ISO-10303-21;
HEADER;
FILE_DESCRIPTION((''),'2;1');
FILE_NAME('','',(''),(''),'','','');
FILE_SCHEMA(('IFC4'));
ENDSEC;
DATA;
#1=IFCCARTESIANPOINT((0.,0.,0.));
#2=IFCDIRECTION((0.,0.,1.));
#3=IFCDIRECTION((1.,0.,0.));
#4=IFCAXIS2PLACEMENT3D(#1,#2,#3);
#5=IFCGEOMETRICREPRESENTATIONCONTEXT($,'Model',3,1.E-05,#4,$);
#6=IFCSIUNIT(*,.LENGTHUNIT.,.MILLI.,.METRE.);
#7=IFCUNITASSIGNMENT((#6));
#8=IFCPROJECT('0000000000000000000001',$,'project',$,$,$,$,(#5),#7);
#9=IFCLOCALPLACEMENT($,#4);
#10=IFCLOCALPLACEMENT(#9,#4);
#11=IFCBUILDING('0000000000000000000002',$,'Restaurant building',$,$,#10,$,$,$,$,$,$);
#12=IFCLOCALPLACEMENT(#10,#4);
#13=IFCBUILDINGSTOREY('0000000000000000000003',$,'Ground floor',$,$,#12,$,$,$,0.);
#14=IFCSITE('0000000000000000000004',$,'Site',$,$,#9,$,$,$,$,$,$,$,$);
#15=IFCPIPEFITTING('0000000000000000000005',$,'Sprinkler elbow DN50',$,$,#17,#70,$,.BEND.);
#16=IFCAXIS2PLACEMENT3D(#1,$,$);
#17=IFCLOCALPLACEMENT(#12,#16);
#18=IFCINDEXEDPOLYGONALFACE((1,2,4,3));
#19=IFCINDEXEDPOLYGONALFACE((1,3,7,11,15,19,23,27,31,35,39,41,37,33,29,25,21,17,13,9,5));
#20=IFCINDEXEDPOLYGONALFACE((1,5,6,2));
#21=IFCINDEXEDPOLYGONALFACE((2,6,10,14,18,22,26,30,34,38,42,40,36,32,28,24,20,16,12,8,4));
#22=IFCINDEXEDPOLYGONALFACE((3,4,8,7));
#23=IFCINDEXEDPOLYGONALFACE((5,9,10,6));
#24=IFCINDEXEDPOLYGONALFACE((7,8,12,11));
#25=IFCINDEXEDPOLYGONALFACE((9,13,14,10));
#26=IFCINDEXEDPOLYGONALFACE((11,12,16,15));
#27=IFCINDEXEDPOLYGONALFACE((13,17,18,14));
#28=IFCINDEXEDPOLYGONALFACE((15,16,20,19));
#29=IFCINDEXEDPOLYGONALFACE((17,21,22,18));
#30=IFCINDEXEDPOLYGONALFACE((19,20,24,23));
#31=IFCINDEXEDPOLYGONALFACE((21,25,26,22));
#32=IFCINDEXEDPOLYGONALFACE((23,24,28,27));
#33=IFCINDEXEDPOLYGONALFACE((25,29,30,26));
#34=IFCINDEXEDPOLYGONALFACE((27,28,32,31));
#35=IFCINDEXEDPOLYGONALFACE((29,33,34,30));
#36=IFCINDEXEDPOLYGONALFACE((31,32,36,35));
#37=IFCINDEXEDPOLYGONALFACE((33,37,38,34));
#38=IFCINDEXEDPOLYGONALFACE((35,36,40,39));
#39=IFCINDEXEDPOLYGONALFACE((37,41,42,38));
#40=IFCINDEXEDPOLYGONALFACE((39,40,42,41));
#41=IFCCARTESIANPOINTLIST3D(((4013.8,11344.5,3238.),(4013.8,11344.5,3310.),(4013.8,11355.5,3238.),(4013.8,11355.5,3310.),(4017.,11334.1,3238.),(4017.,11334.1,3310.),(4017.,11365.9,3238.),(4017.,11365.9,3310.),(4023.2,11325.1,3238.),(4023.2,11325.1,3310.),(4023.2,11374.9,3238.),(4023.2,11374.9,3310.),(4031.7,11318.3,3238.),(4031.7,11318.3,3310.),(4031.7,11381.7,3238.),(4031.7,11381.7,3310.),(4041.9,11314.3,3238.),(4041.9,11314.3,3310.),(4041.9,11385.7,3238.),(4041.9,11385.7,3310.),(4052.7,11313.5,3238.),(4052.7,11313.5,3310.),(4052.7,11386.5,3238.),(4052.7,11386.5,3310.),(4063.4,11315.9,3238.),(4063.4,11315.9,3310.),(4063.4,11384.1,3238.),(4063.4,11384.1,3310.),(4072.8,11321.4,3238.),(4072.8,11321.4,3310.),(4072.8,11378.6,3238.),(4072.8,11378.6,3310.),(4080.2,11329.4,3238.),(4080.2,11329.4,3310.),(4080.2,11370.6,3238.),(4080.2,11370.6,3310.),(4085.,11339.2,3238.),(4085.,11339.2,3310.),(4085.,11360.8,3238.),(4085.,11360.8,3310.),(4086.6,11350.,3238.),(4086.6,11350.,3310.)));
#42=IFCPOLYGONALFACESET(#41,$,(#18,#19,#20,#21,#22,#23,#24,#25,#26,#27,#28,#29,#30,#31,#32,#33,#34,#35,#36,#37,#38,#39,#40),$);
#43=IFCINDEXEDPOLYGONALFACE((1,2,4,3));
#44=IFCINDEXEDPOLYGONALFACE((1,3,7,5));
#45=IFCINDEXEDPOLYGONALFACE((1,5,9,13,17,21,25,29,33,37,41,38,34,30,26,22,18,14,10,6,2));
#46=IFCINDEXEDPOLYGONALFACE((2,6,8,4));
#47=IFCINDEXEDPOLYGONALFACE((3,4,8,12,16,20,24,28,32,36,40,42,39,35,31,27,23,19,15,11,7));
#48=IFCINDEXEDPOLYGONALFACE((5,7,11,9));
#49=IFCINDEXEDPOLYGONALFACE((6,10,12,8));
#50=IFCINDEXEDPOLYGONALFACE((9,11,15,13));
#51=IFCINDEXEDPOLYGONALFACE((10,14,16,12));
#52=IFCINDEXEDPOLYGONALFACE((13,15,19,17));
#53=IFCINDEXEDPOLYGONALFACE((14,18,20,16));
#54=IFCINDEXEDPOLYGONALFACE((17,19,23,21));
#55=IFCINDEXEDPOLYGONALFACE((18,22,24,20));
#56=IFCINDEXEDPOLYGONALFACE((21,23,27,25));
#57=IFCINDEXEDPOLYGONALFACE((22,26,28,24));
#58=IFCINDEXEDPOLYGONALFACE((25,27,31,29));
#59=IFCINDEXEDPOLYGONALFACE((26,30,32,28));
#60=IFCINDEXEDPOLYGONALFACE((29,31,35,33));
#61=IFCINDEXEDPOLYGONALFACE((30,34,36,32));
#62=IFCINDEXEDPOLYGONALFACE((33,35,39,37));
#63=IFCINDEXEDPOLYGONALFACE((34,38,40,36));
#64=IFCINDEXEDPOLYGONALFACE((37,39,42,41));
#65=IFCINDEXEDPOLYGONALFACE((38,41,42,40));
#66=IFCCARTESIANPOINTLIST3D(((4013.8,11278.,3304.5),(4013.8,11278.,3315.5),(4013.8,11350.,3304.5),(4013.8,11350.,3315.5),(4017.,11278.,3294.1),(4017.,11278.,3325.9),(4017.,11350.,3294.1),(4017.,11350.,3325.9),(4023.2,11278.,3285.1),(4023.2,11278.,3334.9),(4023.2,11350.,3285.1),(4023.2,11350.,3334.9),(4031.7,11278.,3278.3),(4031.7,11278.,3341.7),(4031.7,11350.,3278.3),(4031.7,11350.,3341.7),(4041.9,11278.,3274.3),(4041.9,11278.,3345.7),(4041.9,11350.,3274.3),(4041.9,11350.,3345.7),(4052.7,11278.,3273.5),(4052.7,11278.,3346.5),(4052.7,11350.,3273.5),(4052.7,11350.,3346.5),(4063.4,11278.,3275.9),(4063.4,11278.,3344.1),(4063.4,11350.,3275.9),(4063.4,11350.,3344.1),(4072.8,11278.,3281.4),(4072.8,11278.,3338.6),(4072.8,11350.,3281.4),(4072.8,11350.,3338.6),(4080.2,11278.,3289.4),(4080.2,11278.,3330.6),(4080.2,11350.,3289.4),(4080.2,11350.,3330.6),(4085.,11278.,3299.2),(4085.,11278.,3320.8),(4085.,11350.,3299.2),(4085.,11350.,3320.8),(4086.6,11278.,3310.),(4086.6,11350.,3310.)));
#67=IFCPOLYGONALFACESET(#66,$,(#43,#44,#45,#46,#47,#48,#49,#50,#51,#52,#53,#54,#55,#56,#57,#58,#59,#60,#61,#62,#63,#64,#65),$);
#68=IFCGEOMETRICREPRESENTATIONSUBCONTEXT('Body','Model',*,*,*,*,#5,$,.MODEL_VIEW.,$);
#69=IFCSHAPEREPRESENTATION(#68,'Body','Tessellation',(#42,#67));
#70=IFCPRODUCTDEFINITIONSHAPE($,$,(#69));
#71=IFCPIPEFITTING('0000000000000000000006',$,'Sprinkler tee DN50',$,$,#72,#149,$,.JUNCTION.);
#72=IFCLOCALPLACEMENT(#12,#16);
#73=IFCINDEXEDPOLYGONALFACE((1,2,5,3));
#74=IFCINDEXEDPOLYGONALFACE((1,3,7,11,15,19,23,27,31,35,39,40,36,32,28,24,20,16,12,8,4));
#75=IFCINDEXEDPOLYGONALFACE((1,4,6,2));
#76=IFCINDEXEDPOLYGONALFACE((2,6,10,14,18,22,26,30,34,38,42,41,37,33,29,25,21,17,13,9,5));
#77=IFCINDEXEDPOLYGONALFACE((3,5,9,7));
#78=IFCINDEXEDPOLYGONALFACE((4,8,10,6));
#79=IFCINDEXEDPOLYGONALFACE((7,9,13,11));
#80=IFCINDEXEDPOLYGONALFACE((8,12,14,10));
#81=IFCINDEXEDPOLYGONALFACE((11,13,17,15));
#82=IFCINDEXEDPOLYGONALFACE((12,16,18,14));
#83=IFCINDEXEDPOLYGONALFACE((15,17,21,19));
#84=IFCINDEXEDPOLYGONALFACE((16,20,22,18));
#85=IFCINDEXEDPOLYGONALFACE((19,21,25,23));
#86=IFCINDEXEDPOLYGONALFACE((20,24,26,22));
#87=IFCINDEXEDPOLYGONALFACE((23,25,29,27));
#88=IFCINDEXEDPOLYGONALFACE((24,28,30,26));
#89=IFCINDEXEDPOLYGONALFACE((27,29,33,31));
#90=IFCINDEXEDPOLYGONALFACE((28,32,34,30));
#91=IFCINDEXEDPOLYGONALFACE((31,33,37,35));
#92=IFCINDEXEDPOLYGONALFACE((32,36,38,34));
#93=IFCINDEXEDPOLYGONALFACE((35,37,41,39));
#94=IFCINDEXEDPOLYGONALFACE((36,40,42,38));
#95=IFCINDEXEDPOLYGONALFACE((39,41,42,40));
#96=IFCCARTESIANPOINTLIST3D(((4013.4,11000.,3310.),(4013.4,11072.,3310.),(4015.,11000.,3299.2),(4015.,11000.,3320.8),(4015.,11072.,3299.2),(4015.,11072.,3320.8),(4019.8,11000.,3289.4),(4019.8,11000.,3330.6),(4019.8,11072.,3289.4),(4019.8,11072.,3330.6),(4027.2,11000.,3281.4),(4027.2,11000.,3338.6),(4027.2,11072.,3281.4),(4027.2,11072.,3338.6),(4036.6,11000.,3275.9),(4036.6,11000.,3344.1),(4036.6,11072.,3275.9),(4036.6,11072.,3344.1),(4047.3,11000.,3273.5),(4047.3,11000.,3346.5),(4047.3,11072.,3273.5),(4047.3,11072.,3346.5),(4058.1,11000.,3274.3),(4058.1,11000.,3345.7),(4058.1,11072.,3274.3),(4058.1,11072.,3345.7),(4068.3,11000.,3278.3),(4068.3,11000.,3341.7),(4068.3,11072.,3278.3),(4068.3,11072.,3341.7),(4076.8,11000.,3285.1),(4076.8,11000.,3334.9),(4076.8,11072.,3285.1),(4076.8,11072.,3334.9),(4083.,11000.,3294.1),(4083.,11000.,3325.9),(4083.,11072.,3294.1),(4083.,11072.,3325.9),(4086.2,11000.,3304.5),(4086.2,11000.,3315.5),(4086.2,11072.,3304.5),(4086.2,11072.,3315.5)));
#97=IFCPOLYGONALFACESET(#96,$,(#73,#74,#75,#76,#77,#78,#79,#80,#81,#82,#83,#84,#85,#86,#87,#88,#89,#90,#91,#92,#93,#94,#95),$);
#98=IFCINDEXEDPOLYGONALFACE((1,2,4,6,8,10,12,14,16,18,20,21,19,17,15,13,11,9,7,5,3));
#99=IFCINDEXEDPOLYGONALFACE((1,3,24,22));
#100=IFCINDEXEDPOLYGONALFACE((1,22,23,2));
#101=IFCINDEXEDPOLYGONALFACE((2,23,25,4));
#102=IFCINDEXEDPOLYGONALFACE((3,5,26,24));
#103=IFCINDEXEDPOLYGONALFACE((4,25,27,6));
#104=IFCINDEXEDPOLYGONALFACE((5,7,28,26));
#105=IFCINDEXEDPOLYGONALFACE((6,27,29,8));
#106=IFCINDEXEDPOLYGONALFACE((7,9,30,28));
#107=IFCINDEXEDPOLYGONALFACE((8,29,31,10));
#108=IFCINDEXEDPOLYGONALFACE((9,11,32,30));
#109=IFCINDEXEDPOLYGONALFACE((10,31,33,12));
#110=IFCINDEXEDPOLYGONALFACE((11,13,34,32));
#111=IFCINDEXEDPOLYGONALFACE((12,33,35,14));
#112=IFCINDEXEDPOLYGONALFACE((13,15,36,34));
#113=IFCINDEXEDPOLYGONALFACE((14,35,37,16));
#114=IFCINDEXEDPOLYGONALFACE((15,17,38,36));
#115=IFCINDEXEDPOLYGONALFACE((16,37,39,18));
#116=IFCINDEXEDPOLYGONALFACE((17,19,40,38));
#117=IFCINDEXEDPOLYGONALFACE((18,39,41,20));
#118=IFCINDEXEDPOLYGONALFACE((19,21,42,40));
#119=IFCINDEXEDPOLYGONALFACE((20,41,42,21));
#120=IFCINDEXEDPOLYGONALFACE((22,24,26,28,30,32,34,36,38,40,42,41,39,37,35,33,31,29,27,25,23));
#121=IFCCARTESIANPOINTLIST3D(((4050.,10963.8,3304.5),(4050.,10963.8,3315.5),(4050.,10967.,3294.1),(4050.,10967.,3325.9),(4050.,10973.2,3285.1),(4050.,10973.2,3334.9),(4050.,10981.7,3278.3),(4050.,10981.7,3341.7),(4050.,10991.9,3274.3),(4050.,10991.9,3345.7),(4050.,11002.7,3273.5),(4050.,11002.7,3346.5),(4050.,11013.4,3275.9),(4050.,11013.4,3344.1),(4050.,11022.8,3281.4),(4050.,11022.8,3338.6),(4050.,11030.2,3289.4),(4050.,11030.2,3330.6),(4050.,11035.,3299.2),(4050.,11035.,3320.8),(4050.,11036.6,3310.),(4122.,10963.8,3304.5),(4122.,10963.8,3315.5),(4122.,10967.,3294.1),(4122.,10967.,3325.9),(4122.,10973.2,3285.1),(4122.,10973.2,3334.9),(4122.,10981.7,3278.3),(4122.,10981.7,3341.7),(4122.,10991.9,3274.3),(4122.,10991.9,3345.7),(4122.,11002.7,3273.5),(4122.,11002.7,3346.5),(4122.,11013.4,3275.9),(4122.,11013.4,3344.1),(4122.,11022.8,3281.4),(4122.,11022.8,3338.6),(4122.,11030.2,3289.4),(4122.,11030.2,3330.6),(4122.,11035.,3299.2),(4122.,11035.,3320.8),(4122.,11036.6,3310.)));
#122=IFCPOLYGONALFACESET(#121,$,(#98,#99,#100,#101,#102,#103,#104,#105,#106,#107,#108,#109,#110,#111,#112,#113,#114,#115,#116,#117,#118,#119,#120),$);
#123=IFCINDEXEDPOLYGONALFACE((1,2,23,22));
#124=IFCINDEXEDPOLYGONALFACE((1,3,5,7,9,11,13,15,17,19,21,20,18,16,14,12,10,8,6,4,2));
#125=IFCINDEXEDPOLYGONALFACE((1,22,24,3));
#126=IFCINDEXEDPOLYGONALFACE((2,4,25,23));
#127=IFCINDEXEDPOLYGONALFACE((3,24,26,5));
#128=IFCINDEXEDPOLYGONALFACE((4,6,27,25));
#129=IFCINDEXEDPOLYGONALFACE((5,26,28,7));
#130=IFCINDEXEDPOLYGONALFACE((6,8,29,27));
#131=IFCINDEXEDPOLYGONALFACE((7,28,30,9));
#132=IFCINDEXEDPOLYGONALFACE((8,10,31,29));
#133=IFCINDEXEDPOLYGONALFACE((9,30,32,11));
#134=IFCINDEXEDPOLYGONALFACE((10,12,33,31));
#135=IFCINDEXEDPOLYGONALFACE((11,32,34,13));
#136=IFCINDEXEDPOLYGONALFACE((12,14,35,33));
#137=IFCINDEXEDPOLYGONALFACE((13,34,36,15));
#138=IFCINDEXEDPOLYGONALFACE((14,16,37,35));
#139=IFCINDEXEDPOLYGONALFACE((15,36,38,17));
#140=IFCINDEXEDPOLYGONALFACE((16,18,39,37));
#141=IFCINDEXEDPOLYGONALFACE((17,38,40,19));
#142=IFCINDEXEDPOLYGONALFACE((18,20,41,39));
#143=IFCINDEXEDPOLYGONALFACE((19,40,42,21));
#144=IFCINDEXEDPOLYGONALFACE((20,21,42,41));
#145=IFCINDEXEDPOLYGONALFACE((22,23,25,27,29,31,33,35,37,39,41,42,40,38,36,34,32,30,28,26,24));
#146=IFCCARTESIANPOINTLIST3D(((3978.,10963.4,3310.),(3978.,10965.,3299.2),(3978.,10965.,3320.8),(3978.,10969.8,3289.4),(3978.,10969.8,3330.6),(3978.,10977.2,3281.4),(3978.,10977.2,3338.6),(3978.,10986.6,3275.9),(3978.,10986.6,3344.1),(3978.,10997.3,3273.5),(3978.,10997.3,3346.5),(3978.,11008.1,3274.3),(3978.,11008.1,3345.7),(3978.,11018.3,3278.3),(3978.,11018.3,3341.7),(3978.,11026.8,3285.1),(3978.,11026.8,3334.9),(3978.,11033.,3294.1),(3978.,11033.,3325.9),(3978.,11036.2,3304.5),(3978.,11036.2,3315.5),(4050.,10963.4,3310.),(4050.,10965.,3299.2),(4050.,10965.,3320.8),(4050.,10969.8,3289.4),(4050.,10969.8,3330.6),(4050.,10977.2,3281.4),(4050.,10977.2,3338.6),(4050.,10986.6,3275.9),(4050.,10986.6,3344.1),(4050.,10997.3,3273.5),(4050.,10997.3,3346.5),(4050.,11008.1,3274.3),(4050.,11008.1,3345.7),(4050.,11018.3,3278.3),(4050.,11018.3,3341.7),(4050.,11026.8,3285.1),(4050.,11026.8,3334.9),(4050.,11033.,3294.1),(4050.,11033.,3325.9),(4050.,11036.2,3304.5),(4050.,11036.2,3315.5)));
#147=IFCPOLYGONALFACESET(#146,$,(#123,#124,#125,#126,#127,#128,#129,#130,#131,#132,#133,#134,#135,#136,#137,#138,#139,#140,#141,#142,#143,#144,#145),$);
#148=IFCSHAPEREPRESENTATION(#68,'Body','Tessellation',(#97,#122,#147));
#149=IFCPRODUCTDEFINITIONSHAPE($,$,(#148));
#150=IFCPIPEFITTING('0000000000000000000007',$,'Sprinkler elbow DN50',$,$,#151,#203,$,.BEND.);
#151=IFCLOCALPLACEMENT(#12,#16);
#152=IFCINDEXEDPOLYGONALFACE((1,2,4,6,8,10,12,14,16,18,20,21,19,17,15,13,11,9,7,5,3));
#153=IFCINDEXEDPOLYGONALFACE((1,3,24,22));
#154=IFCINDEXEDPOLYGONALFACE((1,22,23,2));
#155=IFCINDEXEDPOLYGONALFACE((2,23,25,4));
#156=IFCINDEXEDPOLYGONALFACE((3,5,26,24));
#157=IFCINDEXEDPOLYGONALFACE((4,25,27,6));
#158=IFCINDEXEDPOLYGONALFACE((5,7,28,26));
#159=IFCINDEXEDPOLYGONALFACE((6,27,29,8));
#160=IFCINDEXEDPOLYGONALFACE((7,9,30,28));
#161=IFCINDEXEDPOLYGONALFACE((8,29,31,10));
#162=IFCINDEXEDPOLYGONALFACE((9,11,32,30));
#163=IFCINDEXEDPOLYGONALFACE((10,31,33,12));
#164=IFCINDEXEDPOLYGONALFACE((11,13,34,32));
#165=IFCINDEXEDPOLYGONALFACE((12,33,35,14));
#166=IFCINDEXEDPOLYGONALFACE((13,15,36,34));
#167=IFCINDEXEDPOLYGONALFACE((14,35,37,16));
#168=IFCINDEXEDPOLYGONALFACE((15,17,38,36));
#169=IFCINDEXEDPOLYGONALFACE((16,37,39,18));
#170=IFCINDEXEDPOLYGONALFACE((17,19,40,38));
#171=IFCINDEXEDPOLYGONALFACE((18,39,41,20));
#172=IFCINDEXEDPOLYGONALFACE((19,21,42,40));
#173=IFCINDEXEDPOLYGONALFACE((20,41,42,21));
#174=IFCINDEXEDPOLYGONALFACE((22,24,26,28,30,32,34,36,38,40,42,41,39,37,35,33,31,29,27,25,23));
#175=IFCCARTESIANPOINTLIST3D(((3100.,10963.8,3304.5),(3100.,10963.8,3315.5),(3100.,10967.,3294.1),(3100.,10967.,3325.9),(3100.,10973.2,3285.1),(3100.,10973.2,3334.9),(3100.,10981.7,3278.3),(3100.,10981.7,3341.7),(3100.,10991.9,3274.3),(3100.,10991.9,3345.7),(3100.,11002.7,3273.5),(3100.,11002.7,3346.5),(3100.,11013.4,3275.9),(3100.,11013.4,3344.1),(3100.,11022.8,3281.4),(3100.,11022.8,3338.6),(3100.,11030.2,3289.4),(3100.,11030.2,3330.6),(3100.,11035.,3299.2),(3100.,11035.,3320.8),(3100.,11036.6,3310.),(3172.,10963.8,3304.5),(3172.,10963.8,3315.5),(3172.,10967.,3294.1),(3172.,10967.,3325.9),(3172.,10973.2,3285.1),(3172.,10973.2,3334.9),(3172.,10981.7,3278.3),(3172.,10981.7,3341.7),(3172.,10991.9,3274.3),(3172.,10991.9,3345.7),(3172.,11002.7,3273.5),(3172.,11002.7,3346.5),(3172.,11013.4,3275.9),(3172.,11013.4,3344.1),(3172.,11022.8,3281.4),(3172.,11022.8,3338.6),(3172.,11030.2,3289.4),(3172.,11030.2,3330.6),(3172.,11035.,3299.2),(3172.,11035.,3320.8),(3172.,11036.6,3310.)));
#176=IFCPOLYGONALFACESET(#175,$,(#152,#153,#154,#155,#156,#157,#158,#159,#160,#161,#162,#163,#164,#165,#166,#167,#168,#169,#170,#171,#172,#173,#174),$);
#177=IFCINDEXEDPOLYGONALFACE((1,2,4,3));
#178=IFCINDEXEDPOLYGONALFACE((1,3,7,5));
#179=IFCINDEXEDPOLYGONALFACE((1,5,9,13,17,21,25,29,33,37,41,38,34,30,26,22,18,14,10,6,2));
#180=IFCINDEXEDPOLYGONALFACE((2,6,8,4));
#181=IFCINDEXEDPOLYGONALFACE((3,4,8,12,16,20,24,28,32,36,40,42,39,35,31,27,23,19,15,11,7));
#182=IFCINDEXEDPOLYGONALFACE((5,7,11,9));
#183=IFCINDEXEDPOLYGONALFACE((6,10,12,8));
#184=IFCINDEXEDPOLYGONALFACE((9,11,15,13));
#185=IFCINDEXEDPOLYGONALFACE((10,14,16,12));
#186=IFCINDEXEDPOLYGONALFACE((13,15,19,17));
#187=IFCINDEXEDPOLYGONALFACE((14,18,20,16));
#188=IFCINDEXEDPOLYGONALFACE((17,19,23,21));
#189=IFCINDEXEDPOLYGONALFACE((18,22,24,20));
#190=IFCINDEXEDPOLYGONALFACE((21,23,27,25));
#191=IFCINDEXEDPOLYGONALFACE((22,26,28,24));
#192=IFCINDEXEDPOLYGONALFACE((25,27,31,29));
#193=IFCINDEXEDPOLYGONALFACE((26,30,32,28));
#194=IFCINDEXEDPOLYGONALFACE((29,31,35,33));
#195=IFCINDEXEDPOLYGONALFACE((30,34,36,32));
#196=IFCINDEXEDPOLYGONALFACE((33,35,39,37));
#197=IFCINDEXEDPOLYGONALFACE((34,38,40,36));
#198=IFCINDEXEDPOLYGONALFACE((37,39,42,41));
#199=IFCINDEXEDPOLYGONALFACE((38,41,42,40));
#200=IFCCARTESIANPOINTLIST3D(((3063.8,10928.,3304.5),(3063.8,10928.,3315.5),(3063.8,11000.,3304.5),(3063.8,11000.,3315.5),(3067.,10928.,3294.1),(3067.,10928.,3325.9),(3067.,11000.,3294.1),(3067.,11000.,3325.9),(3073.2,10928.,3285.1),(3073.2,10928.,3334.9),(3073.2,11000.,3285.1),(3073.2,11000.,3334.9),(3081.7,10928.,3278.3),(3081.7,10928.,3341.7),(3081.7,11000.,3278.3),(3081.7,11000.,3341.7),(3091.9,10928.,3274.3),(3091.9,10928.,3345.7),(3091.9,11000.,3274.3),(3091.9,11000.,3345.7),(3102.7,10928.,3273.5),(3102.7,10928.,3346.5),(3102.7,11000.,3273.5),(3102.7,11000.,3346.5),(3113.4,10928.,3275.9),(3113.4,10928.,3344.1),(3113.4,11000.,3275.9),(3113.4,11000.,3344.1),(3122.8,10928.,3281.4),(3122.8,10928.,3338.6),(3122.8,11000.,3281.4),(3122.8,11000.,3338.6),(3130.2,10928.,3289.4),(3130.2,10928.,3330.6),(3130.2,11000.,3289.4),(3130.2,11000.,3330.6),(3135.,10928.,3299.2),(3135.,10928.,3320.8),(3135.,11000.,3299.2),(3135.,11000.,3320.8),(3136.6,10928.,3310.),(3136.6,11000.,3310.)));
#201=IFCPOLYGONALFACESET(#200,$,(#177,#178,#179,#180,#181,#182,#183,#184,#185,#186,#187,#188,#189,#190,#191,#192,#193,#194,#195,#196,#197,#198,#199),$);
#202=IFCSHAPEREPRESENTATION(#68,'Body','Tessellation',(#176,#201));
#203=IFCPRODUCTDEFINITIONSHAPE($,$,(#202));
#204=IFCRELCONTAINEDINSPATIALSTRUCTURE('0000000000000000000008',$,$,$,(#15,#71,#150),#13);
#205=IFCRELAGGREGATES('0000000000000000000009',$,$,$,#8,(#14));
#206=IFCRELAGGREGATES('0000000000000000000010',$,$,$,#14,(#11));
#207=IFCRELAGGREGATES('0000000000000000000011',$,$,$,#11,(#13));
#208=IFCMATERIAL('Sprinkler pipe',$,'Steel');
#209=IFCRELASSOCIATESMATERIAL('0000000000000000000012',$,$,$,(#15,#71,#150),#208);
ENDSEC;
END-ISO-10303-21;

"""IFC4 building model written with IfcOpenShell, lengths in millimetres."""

from ifc_helpers import new_model, si_unit, frame, origin_with_axes, origin_2d, place, context, subcontext, project, spatial, circle, extrude, material, element, save


model = new_model("IFC4")

# Units and contexts
model_context = context("Model", 3, precision=1e-05, world=origin_with_axes())
body_context = subcontext(model_context, "Body", "Model", "MODEL_VIEW")
ifc_project = project(units=[si_unit("LENGTHUNIT", "METRE", prefix="MILLI")], contexts=[model_context])

# Site, building, storey
site_placement = place(None, origin_with_axes())
site = spatial("IfcSite", under=ifc_project, at=site_placement, Name="Site")
building_placement = place(site_placement, origin_with_axes())
building = spatial("IfcBuilding", under=site, at=building_placement, Name="Restaurant building")
storey_placement = place(building_placement, origin_with_axes())
storey = spatial("IfcBuildingStorey", under=building, at=storey_placement, Name="Ground floor", Elevation=0.0)

# Shared definitions
ifc_material_1 = material(Name="Sprinkler pipe", Category="Steel")

# Pipe fittings
pipe_fitting_1_placement = place(storey_placement, frame((4050.0, 11350.0, 3310.0)))
element("IfcPipeFitting", 1, at=pipe_fitting_1_placement, inside=storey, material=ifc_material_1, Name="Sprinkler elbow DN50", PredefinedType="BEND", context=body_context, shape_type="SweptSolid", body=[
    extrude(circle(Radius=36.6, at=origin_2d()), frame((0.0, 0.0, 0.0), z_axis=(0.0, 0.0, -1.0), x_axis=(1.0, 0.0, 0.0)), (0.0, 0.0, 1.0), 72.0),
    extrude(circle(Radius=36.6, at=origin_2d()), frame((0.0, 0.0, 0.0), z_axis=(0.0, -1.0, 0.0), x_axis=(1.0, 0.0, 0.0)), (0.0, 0.0, 1.0), 72.0),
])
pipe_fitting_2_placement = place(storey_placement, frame((4050.0, 11000.0, 3310.0)))
element("IfcPipeFitting", 2, at=pipe_fitting_2_placement, inside=storey, material=ifc_material_1, Name="Sprinkler tee DN50", PredefinedType="JUNCTION", context=body_context, shape_type="SweptSolid", body=[
    extrude(circle(Radius=36.6, at=origin_2d()), frame((0.0, 0.0, 0.0), z_axis=(0.0, 1.0, 0.0), x_axis=(-1.0, 0.0, 0.0)), (0.0, 0.0, 1.0), 72.0),
    extrude(circle(Radius=36.6, at=origin_2d()), frame((0.0, 0.0, 0.0), z_axis=(1.0, 0.0, 0.0), x_axis=(0.0, 1.0, 0.0)), (0.0, 0.0, 1.0), 72.0),
    extrude(circle(Radius=36.6, at=origin_2d()), frame((0.0, 0.0, 0.0), z_axis=(-1.0, 0.0, 0.0), x_axis=(0.0, -1.0, 0.0)), (0.0, 0.0, 1.0), 72.0),
])
pipe_fitting_3_placement = place(storey_placement, frame((3100.0, 11000.0, 3310.0)))
element("IfcPipeFitting", 3, at=pipe_fitting_3_placement, inside=storey, material=ifc_material_1, Name="Sprinkler elbow DN50", PredefinedType="BEND", context=body_context, shape_type="SweptSolid", body=[
    extrude(circle(Radius=36.6, at=origin_2d()), frame((0.0, 0.0, 0.0), z_axis=(1.0, 0.0, 0.0), x_axis=(0.0, 1.0, 0.0)), (0.0, 0.0, 1.0), 72.0),
    extrude(circle(Radius=36.6, at=origin_2d()), frame((0.0, 0.0, 0.0), z_axis=(0.0, -1.0, 0.0), x_axis=(1.0, 0.0, 0.0)), (0.0, 0.0, 1.0), 72.0),
])

save(model, "model.ifc")
